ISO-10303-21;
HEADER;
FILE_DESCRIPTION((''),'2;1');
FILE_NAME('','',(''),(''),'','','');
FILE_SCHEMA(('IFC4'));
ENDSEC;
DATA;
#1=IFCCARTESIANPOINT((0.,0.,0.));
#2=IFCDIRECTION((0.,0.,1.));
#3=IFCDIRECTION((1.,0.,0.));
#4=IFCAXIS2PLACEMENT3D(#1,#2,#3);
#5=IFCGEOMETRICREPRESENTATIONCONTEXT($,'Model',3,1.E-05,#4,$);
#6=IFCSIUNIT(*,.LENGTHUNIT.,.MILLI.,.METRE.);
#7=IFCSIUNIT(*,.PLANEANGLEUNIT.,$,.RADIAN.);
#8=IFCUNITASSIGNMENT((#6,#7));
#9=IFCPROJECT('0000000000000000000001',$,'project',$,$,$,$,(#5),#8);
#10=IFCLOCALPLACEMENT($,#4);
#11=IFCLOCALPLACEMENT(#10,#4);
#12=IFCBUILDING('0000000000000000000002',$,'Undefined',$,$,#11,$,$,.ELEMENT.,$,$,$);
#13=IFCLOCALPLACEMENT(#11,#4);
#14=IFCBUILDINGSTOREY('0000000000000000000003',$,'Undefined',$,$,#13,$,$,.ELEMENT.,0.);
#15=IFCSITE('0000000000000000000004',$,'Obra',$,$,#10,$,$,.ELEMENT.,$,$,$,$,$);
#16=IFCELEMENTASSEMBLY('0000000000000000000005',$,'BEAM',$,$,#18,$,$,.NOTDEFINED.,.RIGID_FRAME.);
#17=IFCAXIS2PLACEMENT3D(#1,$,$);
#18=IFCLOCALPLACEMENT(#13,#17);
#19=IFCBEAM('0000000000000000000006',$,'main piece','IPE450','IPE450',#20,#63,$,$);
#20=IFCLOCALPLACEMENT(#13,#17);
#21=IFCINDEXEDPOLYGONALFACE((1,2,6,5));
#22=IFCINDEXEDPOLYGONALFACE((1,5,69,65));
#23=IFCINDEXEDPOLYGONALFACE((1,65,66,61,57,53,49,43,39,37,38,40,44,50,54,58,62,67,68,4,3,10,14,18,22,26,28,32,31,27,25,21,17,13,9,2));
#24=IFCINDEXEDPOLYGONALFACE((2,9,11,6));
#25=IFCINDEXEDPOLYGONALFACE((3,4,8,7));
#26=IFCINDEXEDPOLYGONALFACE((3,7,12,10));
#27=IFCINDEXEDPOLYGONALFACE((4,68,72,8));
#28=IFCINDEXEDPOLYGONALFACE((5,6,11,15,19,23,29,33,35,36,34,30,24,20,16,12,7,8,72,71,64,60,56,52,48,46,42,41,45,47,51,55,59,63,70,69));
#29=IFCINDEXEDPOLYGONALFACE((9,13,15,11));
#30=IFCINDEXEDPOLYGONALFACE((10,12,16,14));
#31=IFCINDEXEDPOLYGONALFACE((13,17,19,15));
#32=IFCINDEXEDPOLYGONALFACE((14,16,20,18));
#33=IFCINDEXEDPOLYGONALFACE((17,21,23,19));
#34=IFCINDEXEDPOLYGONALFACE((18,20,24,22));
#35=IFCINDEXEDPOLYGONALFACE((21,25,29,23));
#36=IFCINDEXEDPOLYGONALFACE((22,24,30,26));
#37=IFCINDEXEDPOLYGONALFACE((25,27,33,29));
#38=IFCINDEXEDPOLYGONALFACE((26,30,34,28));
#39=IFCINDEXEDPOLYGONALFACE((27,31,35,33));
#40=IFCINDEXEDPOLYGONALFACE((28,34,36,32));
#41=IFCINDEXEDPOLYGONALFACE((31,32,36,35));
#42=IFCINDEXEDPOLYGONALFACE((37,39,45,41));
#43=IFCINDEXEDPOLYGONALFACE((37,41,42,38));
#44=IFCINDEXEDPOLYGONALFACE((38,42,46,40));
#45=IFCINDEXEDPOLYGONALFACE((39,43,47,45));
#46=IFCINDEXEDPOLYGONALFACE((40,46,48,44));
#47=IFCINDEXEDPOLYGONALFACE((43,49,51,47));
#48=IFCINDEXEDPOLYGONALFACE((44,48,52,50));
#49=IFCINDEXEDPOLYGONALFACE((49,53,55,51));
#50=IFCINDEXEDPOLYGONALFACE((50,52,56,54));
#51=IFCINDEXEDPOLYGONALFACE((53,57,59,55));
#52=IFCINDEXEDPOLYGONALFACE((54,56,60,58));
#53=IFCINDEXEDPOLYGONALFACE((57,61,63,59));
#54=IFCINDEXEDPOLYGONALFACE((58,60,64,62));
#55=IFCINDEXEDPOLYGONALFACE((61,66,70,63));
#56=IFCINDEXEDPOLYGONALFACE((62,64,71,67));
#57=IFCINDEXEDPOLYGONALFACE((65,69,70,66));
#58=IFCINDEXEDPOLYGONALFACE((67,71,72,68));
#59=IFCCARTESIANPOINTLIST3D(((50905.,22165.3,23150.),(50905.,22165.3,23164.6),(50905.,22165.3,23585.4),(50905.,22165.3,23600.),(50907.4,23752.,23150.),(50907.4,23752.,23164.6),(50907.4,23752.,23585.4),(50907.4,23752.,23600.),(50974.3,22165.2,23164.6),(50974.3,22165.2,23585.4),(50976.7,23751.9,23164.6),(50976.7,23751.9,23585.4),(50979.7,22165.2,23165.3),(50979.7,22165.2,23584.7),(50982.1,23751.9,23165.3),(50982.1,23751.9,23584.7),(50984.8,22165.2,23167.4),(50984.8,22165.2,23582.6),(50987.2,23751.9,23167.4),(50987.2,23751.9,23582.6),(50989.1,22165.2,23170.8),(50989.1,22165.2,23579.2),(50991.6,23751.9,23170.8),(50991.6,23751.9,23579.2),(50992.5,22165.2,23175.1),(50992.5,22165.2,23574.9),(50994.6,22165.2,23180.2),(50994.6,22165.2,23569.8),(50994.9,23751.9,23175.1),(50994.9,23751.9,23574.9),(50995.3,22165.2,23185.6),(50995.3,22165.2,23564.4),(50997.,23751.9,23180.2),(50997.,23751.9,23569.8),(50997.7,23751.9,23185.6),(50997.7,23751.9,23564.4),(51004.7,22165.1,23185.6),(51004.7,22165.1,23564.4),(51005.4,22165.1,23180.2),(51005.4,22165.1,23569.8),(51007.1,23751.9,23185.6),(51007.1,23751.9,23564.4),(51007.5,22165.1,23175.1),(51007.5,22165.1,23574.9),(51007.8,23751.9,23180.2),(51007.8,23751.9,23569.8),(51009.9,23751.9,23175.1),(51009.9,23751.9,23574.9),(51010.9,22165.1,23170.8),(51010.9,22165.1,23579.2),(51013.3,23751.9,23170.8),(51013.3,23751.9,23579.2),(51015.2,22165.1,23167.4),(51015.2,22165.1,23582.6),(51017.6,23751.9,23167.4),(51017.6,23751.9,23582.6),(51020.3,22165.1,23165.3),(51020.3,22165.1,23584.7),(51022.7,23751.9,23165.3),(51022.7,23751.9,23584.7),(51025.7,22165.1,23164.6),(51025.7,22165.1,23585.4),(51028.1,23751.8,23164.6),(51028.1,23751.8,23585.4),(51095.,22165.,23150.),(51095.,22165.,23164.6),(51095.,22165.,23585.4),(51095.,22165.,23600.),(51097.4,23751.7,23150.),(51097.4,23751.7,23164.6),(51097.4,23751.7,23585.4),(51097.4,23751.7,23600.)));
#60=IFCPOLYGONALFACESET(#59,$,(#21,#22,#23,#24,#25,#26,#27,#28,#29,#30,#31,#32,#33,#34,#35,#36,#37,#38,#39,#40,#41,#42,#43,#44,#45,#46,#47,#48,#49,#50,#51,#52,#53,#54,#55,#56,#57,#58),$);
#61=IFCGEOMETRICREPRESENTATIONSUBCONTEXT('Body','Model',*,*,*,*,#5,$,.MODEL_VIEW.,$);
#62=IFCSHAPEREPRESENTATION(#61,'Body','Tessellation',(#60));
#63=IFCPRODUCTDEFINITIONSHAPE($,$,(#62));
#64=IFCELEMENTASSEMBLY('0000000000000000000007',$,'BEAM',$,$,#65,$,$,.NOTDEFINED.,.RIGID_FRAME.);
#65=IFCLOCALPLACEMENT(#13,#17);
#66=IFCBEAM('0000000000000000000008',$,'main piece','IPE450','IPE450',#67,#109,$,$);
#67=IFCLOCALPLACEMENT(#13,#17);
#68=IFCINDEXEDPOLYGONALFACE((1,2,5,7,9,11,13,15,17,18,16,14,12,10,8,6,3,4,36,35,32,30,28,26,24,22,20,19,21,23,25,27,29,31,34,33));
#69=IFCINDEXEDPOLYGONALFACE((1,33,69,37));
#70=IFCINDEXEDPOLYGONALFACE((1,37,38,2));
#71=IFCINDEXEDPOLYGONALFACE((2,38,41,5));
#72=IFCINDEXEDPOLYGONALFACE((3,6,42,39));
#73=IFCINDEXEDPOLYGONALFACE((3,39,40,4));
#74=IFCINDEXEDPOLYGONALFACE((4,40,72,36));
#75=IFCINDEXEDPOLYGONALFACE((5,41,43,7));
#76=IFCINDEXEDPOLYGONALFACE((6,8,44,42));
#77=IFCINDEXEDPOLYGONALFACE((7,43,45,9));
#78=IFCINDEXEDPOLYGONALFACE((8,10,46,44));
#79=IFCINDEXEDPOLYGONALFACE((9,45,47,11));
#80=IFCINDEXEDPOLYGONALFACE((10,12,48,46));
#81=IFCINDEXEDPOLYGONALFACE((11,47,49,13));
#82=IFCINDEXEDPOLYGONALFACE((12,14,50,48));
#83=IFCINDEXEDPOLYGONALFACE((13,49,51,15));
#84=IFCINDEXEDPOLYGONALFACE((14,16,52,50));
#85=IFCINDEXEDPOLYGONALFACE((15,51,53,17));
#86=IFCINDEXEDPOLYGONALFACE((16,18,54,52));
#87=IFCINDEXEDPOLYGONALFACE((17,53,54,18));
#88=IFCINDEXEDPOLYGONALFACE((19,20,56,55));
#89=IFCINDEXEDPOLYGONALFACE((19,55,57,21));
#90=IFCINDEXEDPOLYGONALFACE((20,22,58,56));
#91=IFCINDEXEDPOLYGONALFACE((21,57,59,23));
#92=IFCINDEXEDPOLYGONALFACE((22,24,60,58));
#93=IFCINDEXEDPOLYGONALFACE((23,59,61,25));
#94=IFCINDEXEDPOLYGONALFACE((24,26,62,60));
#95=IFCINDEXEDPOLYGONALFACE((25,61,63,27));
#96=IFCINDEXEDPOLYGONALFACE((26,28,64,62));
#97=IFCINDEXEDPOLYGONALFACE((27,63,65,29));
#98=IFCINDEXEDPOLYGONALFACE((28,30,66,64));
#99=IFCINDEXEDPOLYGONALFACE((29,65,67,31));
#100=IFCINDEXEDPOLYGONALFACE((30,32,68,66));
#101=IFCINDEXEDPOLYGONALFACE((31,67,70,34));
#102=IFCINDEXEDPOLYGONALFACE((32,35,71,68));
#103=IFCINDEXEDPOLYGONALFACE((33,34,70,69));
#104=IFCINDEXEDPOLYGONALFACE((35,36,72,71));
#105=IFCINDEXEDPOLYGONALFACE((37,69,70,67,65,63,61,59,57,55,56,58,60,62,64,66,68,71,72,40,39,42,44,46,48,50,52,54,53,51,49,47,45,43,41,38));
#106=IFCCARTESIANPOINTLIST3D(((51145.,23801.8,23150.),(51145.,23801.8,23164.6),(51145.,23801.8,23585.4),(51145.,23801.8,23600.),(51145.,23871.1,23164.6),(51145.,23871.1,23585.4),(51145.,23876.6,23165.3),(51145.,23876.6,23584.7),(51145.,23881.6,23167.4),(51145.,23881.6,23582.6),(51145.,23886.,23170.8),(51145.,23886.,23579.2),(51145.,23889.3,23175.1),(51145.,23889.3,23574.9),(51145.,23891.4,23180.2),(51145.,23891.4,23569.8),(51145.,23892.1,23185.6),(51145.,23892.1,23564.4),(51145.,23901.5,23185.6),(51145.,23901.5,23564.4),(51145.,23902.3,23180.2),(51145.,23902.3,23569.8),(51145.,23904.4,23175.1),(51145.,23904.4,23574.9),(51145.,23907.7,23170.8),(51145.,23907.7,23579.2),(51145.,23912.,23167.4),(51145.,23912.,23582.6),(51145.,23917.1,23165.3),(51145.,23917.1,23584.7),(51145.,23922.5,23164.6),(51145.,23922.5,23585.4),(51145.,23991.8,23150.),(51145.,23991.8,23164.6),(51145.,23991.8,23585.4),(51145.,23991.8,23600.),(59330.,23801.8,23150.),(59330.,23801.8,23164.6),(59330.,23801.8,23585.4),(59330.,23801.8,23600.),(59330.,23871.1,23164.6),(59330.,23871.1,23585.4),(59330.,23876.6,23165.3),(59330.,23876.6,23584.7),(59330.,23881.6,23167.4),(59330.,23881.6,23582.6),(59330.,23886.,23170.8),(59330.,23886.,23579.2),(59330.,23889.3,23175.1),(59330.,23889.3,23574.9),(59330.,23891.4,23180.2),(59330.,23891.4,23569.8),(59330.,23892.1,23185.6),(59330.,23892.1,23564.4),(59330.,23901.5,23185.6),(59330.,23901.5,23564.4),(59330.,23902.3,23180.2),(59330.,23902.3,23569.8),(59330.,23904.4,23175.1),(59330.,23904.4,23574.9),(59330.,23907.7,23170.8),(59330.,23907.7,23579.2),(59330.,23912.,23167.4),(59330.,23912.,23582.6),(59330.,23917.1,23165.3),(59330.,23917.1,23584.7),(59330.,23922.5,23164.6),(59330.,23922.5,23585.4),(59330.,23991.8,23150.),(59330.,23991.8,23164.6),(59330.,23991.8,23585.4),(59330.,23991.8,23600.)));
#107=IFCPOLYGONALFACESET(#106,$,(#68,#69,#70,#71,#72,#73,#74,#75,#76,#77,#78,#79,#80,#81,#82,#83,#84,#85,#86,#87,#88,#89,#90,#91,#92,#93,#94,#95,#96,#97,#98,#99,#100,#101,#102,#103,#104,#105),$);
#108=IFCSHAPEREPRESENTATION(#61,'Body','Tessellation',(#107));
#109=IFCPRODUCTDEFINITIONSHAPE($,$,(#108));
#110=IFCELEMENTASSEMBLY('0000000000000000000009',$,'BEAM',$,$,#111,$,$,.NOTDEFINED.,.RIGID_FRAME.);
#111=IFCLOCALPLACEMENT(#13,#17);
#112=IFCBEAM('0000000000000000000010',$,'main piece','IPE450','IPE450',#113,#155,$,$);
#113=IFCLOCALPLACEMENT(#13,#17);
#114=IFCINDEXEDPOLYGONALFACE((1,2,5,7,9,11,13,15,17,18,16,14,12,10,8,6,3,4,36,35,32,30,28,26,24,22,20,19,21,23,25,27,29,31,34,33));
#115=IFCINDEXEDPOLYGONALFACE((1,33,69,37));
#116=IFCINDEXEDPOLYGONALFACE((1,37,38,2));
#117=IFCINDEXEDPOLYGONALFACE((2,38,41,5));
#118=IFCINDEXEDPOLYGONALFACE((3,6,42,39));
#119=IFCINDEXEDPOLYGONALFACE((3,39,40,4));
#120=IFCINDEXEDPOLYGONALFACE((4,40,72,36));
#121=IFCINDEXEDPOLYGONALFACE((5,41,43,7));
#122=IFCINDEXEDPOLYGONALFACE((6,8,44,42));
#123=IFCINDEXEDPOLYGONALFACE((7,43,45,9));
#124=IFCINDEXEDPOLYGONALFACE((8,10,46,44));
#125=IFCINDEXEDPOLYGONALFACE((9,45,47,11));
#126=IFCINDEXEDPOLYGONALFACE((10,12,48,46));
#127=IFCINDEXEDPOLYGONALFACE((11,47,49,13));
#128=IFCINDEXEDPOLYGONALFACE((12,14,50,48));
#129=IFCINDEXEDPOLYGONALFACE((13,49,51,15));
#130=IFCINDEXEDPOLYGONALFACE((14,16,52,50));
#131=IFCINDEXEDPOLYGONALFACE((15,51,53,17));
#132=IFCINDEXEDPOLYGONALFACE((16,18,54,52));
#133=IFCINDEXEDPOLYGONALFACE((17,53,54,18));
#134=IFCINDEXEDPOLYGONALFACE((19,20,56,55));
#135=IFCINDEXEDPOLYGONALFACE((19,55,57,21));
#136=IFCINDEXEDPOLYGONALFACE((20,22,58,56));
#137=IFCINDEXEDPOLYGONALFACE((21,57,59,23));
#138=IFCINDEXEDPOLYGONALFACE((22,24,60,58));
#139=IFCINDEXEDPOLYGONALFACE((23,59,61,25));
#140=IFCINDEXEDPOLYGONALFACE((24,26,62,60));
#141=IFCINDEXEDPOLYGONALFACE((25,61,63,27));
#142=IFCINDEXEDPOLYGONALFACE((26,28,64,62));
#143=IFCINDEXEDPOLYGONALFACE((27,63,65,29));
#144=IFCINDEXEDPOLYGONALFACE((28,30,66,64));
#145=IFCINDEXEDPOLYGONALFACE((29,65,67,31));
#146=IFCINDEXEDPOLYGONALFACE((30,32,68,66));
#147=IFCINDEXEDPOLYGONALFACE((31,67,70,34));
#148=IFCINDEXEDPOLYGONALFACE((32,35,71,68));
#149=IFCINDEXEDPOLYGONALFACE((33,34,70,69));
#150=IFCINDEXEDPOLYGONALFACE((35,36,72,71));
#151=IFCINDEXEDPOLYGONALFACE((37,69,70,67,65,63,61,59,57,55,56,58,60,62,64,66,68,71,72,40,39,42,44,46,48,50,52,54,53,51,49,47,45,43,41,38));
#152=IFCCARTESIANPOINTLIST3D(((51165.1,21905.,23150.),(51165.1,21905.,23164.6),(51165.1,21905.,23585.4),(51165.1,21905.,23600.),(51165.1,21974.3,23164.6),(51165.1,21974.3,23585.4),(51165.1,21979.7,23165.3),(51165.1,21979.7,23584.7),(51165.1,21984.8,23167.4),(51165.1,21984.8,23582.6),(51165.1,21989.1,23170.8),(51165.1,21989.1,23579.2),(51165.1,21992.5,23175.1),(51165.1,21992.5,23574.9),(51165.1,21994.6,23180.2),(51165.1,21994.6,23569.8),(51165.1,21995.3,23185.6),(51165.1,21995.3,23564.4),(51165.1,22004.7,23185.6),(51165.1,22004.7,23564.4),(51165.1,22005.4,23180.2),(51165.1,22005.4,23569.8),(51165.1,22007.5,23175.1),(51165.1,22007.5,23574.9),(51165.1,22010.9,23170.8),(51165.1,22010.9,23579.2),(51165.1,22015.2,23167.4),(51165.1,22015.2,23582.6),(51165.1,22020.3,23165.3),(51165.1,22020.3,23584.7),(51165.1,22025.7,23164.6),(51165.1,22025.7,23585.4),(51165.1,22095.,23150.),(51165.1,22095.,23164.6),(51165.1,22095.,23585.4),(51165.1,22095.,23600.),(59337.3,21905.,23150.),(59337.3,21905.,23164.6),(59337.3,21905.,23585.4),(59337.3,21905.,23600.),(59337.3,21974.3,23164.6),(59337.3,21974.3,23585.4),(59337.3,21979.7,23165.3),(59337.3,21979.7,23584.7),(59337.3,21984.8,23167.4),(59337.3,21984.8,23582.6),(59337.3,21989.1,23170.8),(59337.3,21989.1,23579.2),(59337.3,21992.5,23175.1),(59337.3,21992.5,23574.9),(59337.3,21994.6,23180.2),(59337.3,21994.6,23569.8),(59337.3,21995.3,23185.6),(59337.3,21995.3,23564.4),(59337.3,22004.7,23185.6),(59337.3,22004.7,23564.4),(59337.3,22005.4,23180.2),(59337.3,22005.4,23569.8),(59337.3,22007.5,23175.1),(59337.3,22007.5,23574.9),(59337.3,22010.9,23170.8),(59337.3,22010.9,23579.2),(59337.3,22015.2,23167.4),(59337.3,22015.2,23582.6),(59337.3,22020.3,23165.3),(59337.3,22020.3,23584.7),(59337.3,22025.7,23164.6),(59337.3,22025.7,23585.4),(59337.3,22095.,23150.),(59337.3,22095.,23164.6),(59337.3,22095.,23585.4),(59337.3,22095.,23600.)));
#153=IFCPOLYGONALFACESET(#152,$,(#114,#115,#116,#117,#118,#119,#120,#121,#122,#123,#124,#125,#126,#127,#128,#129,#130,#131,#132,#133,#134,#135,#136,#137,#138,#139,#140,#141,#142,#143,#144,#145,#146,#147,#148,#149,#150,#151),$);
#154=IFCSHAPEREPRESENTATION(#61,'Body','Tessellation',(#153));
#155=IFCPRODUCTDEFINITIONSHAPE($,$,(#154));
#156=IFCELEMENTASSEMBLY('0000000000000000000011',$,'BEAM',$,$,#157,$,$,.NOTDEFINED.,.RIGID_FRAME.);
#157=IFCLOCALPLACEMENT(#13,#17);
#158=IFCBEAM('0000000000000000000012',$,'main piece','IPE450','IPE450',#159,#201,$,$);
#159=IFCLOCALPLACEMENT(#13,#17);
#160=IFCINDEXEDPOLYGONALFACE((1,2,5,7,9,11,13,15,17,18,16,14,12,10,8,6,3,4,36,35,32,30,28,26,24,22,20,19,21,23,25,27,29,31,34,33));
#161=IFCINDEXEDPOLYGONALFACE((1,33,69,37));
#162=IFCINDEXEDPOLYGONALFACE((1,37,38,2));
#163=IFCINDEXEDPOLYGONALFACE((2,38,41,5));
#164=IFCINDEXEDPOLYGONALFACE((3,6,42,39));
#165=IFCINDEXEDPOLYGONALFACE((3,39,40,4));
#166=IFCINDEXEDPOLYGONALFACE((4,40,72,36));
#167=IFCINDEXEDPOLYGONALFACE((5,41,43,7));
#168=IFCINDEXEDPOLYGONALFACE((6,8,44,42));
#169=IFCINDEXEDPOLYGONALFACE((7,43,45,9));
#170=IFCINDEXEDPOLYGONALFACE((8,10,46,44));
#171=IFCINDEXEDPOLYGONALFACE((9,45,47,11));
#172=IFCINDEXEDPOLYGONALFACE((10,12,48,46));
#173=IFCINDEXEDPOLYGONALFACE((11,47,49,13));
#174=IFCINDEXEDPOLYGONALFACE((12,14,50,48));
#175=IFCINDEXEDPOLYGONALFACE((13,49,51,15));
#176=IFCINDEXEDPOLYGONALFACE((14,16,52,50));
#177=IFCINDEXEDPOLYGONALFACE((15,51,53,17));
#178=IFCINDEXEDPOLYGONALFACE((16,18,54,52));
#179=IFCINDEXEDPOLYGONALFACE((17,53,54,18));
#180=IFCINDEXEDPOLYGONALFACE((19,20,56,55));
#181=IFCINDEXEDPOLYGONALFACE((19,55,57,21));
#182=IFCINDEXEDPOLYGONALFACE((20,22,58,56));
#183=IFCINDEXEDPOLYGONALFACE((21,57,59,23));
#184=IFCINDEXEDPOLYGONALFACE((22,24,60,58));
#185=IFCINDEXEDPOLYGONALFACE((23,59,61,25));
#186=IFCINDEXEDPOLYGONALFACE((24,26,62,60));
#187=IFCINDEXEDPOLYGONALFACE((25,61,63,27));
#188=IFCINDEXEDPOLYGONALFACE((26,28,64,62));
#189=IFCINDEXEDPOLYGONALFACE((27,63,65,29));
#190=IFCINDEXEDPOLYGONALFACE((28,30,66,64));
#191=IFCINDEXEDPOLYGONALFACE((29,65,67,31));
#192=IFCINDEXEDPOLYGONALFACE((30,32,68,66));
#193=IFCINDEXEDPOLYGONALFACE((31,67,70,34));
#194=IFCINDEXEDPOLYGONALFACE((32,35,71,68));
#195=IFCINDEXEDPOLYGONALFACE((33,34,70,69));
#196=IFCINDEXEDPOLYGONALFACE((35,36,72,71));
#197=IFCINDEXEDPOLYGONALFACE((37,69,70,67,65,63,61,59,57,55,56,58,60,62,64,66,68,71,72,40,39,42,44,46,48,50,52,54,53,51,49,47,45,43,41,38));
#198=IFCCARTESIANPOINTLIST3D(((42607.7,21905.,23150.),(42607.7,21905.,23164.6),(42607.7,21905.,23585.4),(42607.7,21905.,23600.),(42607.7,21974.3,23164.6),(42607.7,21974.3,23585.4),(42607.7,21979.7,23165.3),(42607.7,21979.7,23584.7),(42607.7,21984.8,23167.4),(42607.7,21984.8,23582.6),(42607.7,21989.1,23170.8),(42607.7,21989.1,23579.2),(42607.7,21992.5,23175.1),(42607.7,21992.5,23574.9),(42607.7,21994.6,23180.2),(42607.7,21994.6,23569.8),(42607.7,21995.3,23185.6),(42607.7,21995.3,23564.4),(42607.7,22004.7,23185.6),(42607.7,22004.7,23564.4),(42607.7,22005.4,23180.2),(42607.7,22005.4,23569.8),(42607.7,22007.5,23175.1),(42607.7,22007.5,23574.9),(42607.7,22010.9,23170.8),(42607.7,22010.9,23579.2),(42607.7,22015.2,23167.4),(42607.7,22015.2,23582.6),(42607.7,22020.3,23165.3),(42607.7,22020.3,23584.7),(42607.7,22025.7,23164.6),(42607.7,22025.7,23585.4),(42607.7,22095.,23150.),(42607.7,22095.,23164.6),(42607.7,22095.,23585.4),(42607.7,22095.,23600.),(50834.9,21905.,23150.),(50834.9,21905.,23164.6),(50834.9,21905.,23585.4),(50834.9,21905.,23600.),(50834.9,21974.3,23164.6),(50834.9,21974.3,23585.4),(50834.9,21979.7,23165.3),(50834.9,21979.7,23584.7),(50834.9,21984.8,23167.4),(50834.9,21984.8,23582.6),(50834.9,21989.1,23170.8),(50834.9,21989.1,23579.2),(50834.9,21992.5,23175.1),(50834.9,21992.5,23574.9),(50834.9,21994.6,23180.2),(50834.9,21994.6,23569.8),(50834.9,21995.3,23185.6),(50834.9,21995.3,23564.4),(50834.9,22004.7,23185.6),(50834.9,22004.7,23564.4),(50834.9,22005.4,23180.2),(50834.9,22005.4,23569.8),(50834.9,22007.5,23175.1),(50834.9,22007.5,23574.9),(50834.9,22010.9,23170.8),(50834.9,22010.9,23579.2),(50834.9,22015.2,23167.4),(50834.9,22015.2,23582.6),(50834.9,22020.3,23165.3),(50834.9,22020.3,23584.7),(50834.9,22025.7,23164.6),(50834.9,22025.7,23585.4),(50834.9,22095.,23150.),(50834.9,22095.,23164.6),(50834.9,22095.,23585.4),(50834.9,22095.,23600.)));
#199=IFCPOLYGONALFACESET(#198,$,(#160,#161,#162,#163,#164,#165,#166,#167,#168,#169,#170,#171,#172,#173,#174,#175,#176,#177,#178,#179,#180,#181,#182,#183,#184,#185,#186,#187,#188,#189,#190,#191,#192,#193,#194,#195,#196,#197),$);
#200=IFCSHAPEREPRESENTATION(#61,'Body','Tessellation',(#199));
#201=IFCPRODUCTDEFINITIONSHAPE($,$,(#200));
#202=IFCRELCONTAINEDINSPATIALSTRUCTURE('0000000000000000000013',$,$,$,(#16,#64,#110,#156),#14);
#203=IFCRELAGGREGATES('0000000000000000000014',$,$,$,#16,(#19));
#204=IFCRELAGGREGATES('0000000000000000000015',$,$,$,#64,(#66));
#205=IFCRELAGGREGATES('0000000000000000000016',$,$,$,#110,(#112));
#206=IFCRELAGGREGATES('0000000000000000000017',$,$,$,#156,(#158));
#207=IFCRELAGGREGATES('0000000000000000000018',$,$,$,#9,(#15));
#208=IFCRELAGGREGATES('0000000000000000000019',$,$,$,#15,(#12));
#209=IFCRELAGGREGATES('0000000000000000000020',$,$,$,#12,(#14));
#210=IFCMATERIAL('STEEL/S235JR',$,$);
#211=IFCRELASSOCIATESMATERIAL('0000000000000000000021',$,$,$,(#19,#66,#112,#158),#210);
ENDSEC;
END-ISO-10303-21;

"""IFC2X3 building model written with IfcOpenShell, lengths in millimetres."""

from ifc_helpers import new_model, si_unit, frame, origin_with_axes, origin_2d_with_axis, place, context, subcontext, project, spatial, i_section, extrude, material, element, aggregate, save


model = new_model("IFC2X3")

# Units and contexts
model_context = context("Model", 3, precision=1e-05, world=origin_with_axes())
body_context = subcontext(model_context, "Body", "Model", "MODEL_VIEW")
ifc_project = project(units=[si_unit("LENGTHUNIT", "METRE", prefix="MILLI"), si_unit("PLANEANGLEUNIT", "RADIAN")], contexts=[model_context])

# Site, building, storey
site_placement = place(None, origin_with_axes())
site = spatial("IfcSite", under=ifc_project, at=site_placement, Name="Obra", CompositionType="ELEMENT")
building_placement = place(site_placement, origin_with_axes())
building = spatial("IfcBuilding", under=site, at=building_placement, Name="Undefined", CompositionType="ELEMENT")
storey_placement = place(building_placement, origin_with_axes())
storey = spatial("IfcBuildingStorey", under=building, at=storey_placement, Name="Undefined", CompositionType="ELEMENT", Elevation=0.0)

# Element assemblies, beams
assembly_1_placement = place(storey_placement, origin_with_axes())
assembly_1 = element("IfcElementAssembly", 1, at=assembly_1_placement, inside=storey, Name="BEAM", AssemblyPlace="NOTDEFINED", PredefinedType="RIGID_FRAME")
ifc_material_1 = material(Name="STEEL/S235JR")
beam_1_placement = place(assembly_1_placement, frame((51000.0, 22165.1, 23375.0), z_axis=(0.0, 0.0, 1.0), x_axis=(0.001516, 0.999999, 0.0)))
beam_1 = element("IfcBeam", 2, at=beam_1_placement, material=ifc_material_1, Name="main piece", Description="IPE450", ObjectType="IPE450", context=body_context, shape_type="SweptSolid", body=[
    extrude(i_section(OverallWidth=190.0, OverallDepth=450.0, WebThickness=9.4, FlangeThickness=14.6, FilletRadius=21.0, at=origin_2d_with_axis()), frame((1586.7, 0.0, 0.0), z_axis=(-1.0, 0.0, 0.0), x_axis=(0.0, -1.0, 0.0)), (0.0, 0.0, 1.0), 1586.7),
])
aggregate(assembly_1, [beam_1])
assembly_2_placement = place(storey_placement, origin_with_axes())
assembly_2 = element("IfcElementAssembly", 3, at=assembly_2_placement, inside=storey, Name="BEAM", AssemblyPlace="NOTDEFINED", PredefinedType="RIGID_FRAME")
beam_2_placement = place(assembly_2_placement, frame((51145.0, 23896.8, 23375.0), z_axis=(0.0, 0.0, 1.0), x_axis=(1.0, 0.0, 0.0)))
beam_2 = element("IfcBeam", 4, at=beam_2_placement, material=ifc_material_1, Name="main piece", Description="IPE450", ObjectType="IPE450", context=body_context, shape_type="SweptSolid", body=[
    extrude(i_section(OverallWidth=190.0, OverallDepth=450.0, WebThickness=9.4, FlangeThickness=14.6, FilletRadius=21.0, at=origin_2d_with_axis()), frame((8185.0, 0.0, 0.0), z_axis=(-1.0, 0.0, 0.0), x_axis=(0.0, -1.0, 0.0)), (0.0, 0.0, 1.0), 8185.0),
])
aggregate(assembly_2, [beam_2])
assembly_3_placement = place(storey_placement, origin_with_axes())
assembly_3 = element("IfcElementAssembly", 5, at=assembly_3_placement, inside=storey, Name="BEAM", AssemblyPlace="NOTDEFINED", PredefinedType="RIGID_FRAME")
beam_3_placement = place(assembly_3_placement, frame((51165.1, 22000.0, 23375.0), z_axis=(0.0, 0.0, 1.0), x_axis=(1.0, 0.0, 0.0)))
beam_3 = element("IfcBeam", 6, at=beam_3_placement, material=ifc_material_1, Name="main piece", Description="IPE450", ObjectType="IPE450", context=body_context, shape_type="SweptSolid", body=[
    extrude(i_section(OverallWidth=190.0, OverallDepth=450.0, WebThickness=9.4, FlangeThickness=14.6, FilletRadius=21.0, at=origin_2d_with_axis()), frame((8172.2, 0.0, 0.0), z_axis=(-1.0, 0.0, 0.0), x_axis=(0.0, -1.0, 0.0)), (0.0, 0.0, 1.0), 8172.2),
])
aggregate(assembly_3, [beam_3])
assembly_4_placement = place(storey_placement, origin_with_axes())
assembly_4 = element("IfcElementAssembly", 7, at=assembly_4_placement, inside=storey, Name="BEAM", AssemblyPlace="NOTDEFINED", PredefinedType="RIGID_FRAME")
beam_4_placement = place(assembly_4_placement, frame((50834.9, 22000.0, 23375.0), z_axis=(0.0, 0.0, 1.0), x_axis=(-1.0, 0.0, 0.0)))
beam_4 = element("IfcBeam", 8, at=beam_4_placement, material=ifc_material_1, Name="main piece", Description="IPE450", ObjectType="IPE450", context=body_context, shape_type="SweptSolid", body=[
    extrude(i_section(OverallWidth=190.0, OverallDepth=450.0, WebThickness=9.4, FlangeThickness=14.6, FilletRadius=21.0, at=origin_2d_with_axis()), frame((8227.2, 0.0, 0.0), z_axis=(-1.0, 0.0, 0.0), x_axis=(0.0, -1.0, 0.0)), (0.0, 0.0, 1.0), 8227.2),
])
aggregate(assembly_4, [beam_4])

save(model, "model.ifc")
